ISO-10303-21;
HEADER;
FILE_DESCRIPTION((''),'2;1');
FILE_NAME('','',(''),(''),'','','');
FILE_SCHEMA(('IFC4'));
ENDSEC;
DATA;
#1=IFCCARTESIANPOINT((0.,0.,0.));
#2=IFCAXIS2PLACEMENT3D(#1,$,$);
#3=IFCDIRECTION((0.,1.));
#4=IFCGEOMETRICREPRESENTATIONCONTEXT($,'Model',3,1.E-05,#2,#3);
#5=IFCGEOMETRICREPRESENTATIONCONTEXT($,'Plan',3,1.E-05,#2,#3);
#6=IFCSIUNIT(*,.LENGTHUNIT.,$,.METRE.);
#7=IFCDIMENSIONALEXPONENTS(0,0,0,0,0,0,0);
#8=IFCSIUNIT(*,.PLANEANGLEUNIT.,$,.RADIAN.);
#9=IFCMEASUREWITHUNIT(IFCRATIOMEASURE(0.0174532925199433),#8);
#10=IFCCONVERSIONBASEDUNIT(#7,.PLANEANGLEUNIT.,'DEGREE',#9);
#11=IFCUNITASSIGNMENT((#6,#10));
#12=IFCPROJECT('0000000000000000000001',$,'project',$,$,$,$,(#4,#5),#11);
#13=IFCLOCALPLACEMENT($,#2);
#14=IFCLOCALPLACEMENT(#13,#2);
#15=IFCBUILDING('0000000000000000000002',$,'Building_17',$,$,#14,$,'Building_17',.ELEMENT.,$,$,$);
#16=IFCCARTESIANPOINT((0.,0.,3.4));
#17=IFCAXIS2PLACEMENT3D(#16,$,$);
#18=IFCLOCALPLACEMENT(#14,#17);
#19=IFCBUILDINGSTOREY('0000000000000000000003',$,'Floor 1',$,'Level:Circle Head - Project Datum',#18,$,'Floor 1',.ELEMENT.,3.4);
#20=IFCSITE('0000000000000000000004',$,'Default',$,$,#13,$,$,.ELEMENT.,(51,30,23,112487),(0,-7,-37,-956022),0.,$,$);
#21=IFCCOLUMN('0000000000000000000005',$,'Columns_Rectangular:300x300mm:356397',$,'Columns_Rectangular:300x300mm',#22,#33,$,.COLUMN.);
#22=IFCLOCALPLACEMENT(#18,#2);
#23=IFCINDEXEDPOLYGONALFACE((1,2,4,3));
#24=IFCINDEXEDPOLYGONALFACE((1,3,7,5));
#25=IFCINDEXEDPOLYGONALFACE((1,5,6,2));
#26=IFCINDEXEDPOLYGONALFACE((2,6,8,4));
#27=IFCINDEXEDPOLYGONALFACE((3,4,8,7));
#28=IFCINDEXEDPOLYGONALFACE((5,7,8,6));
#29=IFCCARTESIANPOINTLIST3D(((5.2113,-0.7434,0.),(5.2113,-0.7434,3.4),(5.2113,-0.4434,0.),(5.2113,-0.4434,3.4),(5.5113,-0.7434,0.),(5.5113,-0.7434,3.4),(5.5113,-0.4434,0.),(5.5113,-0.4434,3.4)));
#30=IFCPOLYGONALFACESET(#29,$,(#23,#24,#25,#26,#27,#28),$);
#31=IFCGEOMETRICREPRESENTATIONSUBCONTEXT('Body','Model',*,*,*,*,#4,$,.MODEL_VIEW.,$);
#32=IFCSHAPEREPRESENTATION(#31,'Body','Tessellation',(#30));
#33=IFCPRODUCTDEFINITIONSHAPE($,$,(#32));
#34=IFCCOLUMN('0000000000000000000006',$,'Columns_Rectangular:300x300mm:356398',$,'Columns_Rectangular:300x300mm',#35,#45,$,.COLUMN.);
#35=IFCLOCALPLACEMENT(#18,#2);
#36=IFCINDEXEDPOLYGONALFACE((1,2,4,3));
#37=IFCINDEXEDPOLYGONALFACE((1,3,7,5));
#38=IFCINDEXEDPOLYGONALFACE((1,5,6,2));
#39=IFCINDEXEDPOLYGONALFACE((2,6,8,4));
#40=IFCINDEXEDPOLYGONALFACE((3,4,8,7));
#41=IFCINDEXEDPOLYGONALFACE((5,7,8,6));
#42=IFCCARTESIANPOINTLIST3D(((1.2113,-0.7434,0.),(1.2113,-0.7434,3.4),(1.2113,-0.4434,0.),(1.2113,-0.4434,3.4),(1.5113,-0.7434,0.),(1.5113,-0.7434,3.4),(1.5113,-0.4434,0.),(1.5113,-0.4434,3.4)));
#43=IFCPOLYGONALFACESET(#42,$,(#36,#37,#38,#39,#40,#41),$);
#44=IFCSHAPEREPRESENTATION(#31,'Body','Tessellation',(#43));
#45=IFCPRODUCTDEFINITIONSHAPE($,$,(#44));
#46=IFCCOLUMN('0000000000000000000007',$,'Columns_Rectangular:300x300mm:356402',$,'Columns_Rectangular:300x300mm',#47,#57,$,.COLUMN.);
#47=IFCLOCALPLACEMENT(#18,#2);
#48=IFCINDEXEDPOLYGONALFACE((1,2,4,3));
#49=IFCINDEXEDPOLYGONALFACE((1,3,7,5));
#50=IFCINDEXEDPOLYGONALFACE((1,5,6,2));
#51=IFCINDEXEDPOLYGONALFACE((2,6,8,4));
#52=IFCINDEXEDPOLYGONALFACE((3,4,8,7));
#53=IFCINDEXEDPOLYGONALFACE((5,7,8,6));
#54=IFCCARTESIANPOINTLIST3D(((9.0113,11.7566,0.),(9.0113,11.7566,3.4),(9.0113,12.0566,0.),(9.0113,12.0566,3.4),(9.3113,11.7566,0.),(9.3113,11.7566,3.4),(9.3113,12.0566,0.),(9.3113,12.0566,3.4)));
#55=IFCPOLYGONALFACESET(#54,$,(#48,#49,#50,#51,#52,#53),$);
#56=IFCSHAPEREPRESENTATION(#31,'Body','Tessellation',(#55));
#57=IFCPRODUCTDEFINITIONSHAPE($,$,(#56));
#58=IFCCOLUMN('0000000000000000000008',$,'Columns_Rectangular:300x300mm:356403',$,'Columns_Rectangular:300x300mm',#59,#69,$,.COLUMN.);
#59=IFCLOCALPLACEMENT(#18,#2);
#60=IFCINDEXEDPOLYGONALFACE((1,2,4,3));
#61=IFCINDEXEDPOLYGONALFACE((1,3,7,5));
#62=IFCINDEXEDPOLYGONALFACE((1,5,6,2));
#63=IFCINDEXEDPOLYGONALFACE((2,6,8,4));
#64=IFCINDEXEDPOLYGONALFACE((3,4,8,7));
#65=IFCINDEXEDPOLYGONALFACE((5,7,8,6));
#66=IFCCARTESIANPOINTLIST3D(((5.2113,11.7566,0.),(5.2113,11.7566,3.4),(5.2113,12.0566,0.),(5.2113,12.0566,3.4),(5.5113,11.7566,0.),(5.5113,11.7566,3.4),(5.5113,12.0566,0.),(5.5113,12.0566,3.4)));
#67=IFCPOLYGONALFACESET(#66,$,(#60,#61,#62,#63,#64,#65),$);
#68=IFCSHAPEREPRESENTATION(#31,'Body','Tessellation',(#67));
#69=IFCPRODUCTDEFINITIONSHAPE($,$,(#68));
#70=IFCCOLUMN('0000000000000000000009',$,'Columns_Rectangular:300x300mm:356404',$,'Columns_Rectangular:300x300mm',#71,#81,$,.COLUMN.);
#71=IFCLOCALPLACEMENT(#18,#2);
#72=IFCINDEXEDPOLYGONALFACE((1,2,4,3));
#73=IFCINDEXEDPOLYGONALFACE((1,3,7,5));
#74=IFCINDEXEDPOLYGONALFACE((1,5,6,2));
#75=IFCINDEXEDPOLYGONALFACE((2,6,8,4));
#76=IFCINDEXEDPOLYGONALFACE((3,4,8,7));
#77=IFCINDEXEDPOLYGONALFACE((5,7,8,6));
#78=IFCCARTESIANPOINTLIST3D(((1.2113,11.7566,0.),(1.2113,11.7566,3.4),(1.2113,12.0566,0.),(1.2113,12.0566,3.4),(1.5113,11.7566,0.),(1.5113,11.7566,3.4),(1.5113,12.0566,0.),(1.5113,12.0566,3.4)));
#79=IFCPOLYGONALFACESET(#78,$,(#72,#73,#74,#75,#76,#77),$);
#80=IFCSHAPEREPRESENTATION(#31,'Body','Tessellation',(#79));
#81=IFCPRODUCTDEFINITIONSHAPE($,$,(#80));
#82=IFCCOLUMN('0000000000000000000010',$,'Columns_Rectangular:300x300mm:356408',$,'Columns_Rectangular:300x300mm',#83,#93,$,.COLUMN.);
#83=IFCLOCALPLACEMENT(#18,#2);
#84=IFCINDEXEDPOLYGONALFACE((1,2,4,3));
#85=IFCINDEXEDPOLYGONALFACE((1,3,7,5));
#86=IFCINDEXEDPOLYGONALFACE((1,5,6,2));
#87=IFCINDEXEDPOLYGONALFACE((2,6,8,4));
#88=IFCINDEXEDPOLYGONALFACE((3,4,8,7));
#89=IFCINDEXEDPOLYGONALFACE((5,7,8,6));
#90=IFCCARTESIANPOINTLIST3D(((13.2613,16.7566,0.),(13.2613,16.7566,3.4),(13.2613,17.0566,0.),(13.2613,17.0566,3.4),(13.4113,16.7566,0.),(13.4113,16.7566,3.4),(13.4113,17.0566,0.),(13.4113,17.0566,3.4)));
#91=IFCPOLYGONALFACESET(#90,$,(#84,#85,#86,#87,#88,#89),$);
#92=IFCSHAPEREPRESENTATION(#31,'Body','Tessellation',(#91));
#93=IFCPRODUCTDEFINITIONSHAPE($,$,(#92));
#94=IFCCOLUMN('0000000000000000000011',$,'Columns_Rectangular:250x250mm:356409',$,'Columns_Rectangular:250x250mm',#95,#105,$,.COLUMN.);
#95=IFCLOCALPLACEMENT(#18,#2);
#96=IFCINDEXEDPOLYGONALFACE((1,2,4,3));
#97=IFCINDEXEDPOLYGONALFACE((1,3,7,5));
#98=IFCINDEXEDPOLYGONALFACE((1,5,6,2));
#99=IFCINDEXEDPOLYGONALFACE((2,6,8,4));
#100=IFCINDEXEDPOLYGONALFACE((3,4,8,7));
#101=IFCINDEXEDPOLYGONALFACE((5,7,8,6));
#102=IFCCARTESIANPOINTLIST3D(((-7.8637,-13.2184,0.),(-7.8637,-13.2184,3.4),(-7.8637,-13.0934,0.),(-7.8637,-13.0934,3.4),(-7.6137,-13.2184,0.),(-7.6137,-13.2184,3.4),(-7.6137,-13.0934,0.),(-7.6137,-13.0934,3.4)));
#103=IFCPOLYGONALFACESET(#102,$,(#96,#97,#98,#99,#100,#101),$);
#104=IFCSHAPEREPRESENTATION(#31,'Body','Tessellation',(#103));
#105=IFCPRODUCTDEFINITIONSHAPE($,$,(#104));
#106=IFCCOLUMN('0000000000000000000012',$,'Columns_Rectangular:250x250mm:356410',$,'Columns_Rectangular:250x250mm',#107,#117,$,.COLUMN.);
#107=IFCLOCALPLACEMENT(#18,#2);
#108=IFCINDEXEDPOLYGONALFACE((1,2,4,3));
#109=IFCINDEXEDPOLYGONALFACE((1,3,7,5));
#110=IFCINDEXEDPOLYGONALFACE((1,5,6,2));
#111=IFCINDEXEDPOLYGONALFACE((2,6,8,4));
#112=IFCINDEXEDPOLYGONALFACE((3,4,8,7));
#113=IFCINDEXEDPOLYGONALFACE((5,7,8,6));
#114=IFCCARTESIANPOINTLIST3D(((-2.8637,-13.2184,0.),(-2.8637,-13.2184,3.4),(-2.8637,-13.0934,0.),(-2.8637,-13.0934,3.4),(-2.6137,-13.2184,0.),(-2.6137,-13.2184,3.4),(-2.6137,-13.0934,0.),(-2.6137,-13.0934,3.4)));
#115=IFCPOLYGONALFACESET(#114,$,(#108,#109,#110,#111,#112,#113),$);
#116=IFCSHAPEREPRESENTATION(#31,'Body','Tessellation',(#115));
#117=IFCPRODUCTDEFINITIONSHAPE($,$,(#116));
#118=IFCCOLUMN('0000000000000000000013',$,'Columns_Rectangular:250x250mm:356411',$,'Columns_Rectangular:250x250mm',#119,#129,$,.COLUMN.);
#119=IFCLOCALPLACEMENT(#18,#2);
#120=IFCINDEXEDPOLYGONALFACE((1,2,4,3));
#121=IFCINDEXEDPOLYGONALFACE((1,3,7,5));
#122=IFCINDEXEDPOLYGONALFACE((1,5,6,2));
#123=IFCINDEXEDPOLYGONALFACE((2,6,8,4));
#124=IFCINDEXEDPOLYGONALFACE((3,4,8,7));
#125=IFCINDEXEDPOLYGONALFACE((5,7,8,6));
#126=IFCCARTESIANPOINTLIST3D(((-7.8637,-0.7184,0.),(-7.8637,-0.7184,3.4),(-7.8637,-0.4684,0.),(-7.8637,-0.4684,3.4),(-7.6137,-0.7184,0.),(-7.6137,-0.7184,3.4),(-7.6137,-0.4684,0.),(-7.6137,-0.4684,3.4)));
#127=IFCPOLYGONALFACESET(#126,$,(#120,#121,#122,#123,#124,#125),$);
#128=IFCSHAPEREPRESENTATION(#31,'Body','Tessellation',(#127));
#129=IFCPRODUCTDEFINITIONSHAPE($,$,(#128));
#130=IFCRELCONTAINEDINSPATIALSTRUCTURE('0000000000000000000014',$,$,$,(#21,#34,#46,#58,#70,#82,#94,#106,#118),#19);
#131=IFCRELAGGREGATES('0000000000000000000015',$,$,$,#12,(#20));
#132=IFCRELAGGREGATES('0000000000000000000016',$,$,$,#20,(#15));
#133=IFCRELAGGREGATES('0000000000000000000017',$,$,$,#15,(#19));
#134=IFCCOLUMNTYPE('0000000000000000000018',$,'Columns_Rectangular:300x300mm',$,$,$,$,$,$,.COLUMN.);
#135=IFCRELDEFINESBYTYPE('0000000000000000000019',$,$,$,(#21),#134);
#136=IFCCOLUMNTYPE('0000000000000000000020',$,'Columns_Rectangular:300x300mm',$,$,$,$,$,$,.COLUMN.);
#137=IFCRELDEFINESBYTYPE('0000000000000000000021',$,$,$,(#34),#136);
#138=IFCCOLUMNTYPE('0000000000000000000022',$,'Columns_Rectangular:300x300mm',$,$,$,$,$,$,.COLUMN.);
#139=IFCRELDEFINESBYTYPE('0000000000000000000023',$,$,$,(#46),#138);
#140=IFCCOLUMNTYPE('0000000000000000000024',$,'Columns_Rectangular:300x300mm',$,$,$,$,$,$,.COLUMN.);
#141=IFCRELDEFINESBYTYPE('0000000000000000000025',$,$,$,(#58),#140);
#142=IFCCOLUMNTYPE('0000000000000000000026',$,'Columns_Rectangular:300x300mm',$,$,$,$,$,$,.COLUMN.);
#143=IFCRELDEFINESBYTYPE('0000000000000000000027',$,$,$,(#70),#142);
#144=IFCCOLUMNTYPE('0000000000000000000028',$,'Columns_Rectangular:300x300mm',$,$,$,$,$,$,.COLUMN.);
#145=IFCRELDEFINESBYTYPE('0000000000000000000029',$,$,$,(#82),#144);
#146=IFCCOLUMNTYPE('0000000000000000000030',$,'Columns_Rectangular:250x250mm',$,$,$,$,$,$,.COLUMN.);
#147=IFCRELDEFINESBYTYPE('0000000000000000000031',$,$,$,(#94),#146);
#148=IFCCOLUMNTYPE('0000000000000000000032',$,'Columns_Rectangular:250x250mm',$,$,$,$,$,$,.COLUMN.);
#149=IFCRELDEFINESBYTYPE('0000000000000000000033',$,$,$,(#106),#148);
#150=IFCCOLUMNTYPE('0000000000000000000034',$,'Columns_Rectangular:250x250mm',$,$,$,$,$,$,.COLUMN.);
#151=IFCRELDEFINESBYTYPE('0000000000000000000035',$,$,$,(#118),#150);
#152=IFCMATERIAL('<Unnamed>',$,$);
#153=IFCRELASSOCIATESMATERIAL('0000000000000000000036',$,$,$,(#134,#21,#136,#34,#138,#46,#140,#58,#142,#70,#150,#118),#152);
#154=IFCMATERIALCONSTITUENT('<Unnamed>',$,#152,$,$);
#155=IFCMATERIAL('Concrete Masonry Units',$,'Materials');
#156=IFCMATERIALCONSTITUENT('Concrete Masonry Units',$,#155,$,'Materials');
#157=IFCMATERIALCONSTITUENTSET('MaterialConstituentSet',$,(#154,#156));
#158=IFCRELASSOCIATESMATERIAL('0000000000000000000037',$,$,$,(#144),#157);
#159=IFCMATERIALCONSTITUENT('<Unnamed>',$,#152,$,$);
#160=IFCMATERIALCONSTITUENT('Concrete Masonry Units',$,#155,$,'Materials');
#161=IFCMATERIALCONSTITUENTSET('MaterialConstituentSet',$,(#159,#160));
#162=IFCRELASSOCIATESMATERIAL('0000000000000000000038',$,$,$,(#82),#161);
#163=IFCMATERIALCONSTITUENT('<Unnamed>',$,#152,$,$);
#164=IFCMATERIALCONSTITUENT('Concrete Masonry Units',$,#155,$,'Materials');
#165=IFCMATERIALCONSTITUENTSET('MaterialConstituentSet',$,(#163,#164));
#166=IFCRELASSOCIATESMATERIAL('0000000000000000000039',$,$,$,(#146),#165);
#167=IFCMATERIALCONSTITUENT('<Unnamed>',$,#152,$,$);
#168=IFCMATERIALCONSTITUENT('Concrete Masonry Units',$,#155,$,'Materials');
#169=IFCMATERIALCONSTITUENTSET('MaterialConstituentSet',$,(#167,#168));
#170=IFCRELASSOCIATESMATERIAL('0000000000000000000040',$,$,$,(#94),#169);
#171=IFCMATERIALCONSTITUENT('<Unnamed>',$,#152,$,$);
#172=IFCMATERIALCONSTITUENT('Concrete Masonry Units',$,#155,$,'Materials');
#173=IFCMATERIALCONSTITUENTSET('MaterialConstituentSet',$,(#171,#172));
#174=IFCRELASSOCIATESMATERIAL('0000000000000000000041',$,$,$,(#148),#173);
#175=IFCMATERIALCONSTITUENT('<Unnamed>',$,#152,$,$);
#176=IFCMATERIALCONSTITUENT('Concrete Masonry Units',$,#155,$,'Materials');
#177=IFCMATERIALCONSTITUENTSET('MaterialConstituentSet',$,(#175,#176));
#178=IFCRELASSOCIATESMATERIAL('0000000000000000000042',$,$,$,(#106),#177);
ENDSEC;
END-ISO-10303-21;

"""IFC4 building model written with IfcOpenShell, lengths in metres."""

from ifc_helpers import new_model, entity, si_unit, converted_unit, direction, frame, origin, place, context, subcontext, project, spatial, indexed_curve, outline, extrude, source, transform, mapped, material, constituent, constituent_set, type_object, type_shapes, element, save


model = new_model("IFC4")

# Units and contexts
model_context = context("Model", 3, precision=1e-05, world=origin(), true_north=direction((0.0, 1.0)))
plan_context = context("Plan", 3, precision=1e-05, world=origin(), true_north=direction((0.0, 1.0)))
body_context = subcontext(model_context, "Body", "Model", "MODEL_VIEW")
ifc_project = project(units=[si_unit("LENGTHUNIT", "METRE"), converted_unit("PLANEANGLEUNIT", "DEGREE", entity("IfcRatioMeasure", 0.0174532925199433), si_unit("PLANEANGLEUNIT", "RADIAN"), dimensions=[0, 0, 0, 0, 0, 0, 0])], contexts=[model_context, plan_context])

# Site, building, storey
site_placement = place(None, origin())
site = spatial("IfcSite", under=ifc_project, at=site_placement, Name="Default", CompositionType="ELEMENT", RefLatitude=(51, 30, 23, 112487), RefLongitude=(0, -7, -37, -956022), RefElevation=0.0)
building_placement = place(site_placement, origin())
building = spatial("IfcBuilding", under=site, at=building_placement, Name="Building_17", LongName="Building_17", CompositionType="ELEMENT")
storey_placement = place(building_placement, frame((0.0, 0.0, 3.4)))
storey = spatial("IfcBuildingStorey", under=building, at=storey_placement, Name="Floor 1", ObjectType="Level:Circle Head - Project Datum", LongName="Floor 1", CompositionType="ELEMENT", Elevation=3.4)

# Columns
ifc_material_1 = material(Name="<Unnamed>")
ifc_material_2 = material(Name="Concrete Masonry Units", Category="Materials")
column_type_1 = type_object("IfcColumnType", Name="Columns_Rectangular:300x300mm", PredefinedType="COLUMN", material=ifc_material_1)
shared_shape_1 = source(origin(), body_context, "Body", "SweptSolid", [
    extrude(outline(indexed_curve([(-0.15, -0.15), (0.15, -0.15), (0.15, 0.15), (-0.15, 0.15), (-0.15, -0.15)], self_intersect=False)), frame((5.3613, -0.5934, 3.4), z_axis=(0.0, 0.0, 1.0), x_axis=(0.0, -1.0, 0.0)), (0.0, 0.0, 1.0), 3.4),
])
type_shapes(column_type_1, [shared_shape_1])
column_1_placement = place(storey_placement, frame((0.0, 0.0, -3.4)))
element("IfcColumn", 1, at=column_1_placement, inside=storey, type_object=column_type_1, material=ifc_material_1, Name="Columns_Rectangular:300x300mm:356397", ObjectType="Columns_Rectangular:300x300mm", PredefinedType="COLUMN", context=body_context, shape_type="MappedRepresentation", body=[
    mapped(shared_shape_1, transform((0.0, 0.0, 0.0), scale=1.0)),
])
column_type_2 = type_object("IfcColumnType", Name="Columns_Rectangular:300x300mm", PredefinedType="COLUMN", material=ifc_material_1)
shared_shape_2 = source(origin(), body_context, "Body", "SweptSolid", [
    extrude(outline(indexed_curve([(-0.15, -0.15), (0.15, -0.15), (0.15, 0.15), (-0.15, 0.15), (-0.15, -0.15)], self_intersect=False)), frame((1.3613, -0.5934, 3.4), z_axis=(0.0, 0.0, 1.0), x_axis=(0.0, -1.0, 0.0)), (0.0, 0.0, 1.0), 3.4),
])
type_shapes(column_type_2, [shared_shape_2])
column_2_placement = place(storey_placement, frame((0.0, 0.0, -3.4)))
element("IfcColumn", 2, at=column_2_placement, inside=storey, type_object=column_type_2, material=ifc_material_1, Name="Columns_Rectangular:300x300mm:356398", ObjectType="Columns_Rectangular:300x300mm", PredefinedType="COLUMN", context=body_context, shape_type="MappedRepresentation", body=[
    mapped(shared_shape_2, transform((0.0, 0.0, 0.0), scale=1.0)),
])
column_type_3 = type_object("IfcColumnType", Name="Columns_Rectangular:300x300mm", PredefinedType="COLUMN", material=ifc_material_1)
shared_shape_3 = source(origin(), body_context, "Body", "SweptSolid", [
    extrude(outline(indexed_curve([(-0.15, -0.15), (0.15, -0.15), (0.15, 0.15), (-0.15, 0.15), (-0.15, -0.15)], self_intersect=False)), frame((9.1613, 11.9066, 3.4), z_axis=(0.0, 0.0, 1.0), x_axis=(0.0, -1.0, 0.0)), (0.0, 0.0, 1.0), 3.4),
])
type_shapes(column_type_3, [shared_shape_3])
column_3_placement = place(storey_placement, frame((0.0, 0.0, -3.4)))
element("IfcColumn", 3, at=column_3_placement, inside=storey, type_object=column_type_3, material=ifc_material_1, Name="Columns_Rectangular:300x300mm:356402", ObjectType="Columns_Rectangular:300x300mm", PredefinedType="COLUMN", context=body_context, shape_type="MappedRepresentation", body=[
    mapped(shared_shape_3, transform((0.0, 0.0, 0.0), scale=1.0)),
])
column_type_4 = type_object("IfcColumnType", Name="Columns_Rectangular:300x300mm", PredefinedType="COLUMN", material=ifc_material_1)
shared_shape_4 = source(origin(), body_context, "Body", "SweptSolid", [
    extrude(outline(indexed_curve([(-0.15, -0.15), (0.15, -0.15), (0.15, 0.15), (-0.15, 0.15), (-0.15, -0.15)], self_intersect=False)), frame((5.3613, 11.9066, 3.4), z_axis=(0.0, 0.0, 1.0), x_axis=(0.0, -1.0, 0.0)), (0.0, 0.0, 1.0), 3.4),
])
type_shapes(column_type_4, [shared_shape_4])
column_4_placement = place(storey_placement, frame((0.0, 0.0, -3.4)))
element("IfcColumn", 4, at=column_4_placement, inside=storey, type_object=column_type_4, material=ifc_material_1, Name="Columns_Rectangular:300x300mm:356403", ObjectType="Columns_Rectangular:300x300mm", PredefinedType="COLUMN", context=body_context, shape_type="MappedRepresentation", body=[
    mapped(shared_shape_4, transform((0.0, 0.0, 0.0), scale=1.0)),
])
column_type_5 = type_object("IfcColumnType", Name="Columns_Rectangular:300x300mm", PredefinedType="COLUMN", material=ifc_material_1)
shared_shape_5 = source(origin(), body_context, "Body", "SweptSolid", [
    extrude(outline(indexed_curve([(-0.15, -0.15), (0.15, -0.15), (0.15, 0.15), (-0.15, 0.15), (-0.15, -0.15)], self_intersect=False)), frame((1.3613, 11.9066, 3.4), z_axis=(0.0, 0.0, 1.0), x_axis=(0.0, -1.0, 0.0)), (0.0, 0.0, 1.0), 3.4),
])
type_shapes(column_type_5, [shared_shape_5])
column_5_placement = place(storey_placement, frame((0.0, 0.0, -3.4)))
element("IfcColumn", 5, at=column_5_placement, inside=storey, type_object=column_type_5, material=ifc_material_1, Name="Columns_Rectangular:300x300mm:356404", ObjectType="Columns_Rectangular:300x300mm", PredefinedType="COLUMN", context=body_context, shape_type="MappedRepresentation", body=[
    mapped(shared_shape_5, transform((0.0, 0.0, 0.0), scale=1.0)),
])
ifc_constituent_1 = constituent(ifc_material_1, Name="<Unnamed>")
ifc_constituent_2 = constituent(ifc_material_2, Name="Concrete Masonry Units", Category="Materials")
ifc_constituent_set_1 = constituent_set(constituents=[ifc_constituent_1, ifc_constituent_2], Name="MaterialConstituentSet")
ifc_constituent_3 = constituent(ifc_material_1, Name="<Unnamed>")
ifc_constituent_4 = constituent(ifc_material_2, Name="Concrete Masonry Units", Category="Materials")
ifc_constituent_set_2 = constituent_set(constituents=[ifc_constituent_3, ifc_constituent_4], Name="MaterialConstituentSet")
column_type_6 = type_object("IfcColumnType", Name="Columns_Rectangular:300x300mm", PredefinedType="COLUMN", material=ifc_constituent_set_2)
shared_shape_6 = source(origin(), body_context, "Body", "SweptSolid", [
    extrude(outline(indexed_curve([(-0.15, -0.075), (0.15, -0.075), (0.15, 0.075), (-0.15, 0.075), (-0.15, -0.075)], self_intersect=False)), frame((13.3363, 16.9066, 3.4), z_axis=(0.0, 0.0, 1.0), x_axis=(0.0, -1.0, 0.0)), (0.0, 0.0, 1.0), 3.4),
])
type_shapes(column_type_6, [shared_shape_6])
column_6_placement = place(storey_placement, frame((0.0, 0.0, -3.4)))
element("IfcColumn", 6, at=column_6_placement, inside=storey, type_object=column_type_6, material=ifc_constituent_set_1, Name="Columns_Rectangular:300x300mm:356408", ObjectType="Columns_Rectangular:300x300mm", PredefinedType="COLUMN", context=body_context, shape_type="MappedRepresentation", body=[
    mapped(shared_shape_6, transform((0.0, 0.0, 0.0), scale=1.0)),
])
ifc_constituent_5 = constituent(ifc_material_1, Name="<Unnamed>")
ifc_constituent_6 = constituent(ifc_material_2, Name="Concrete Masonry Units", Category="Materials")
ifc_constituent_set_3 = constituent_set(constituents=[ifc_constituent_5, ifc_constituent_6], Name="MaterialConstituentSet")
ifc_constituent_7 = constituent(ifc_material_1, Name="<Unnamed>")
ifc_constituent_8 = constituent(ifc_material_2, Name="Concrete Masonry Units", Category="Materials")
ifc_constituent_set_4 = constituent_set(constituents=[ifc_constituent_7, ifc_constituent_8], Name="MaterialConstituentSet")
column_type_7 = type_object("IfcColumnType", Name="Columns_Rectangular:250x250mm", PredefinedType="COLUMN", material=ifc_constituent_set_4)
shared_shape_7 = source(origin(), body_context, "Body", "SweptSolid", [
    extrude(outline(indexed_curve([(-0.0625, -0.125), (0.0625, -0.125), (0.0625, 0.125), (-0.0625, 0.125), (-0.0625, -0.125)], self_intersect=False)), frame((-7.7387, -13.1559, 3.4), z_axis=(0.0, 0.0, 1.0), x_axis=(0.0, -1.0, 0.0)), (0.0, 0.0, 1.0), 3.4),
])
type_shapes(column_type_7, [shared_shape_7])
column_7_placement = place(storey_placement, frame((0.0, 0.0, -3.4)))
element("IfcColumn", 7, at=column_7_placement, inside=storey, type_object=column_type_7, material=ifc_constituent_set_3, Name="Columns_Rectangular:250x250mm:356409", ObjectType="Columns_Rectangular:250x250mm", PredefinedType="COLUMN", context=body_context, shape_type="MappedRepresentation", body=[
    mapped(shared_shape_7, transform((0.0, 0.0, 0.0), scale=1.0)),
])
ifc_constituent_9 = constituent(ifc_material_1, Name="<Unnamed>")
ifc_constituent_10 = constituent(ifc_material_2, Name="Concrete Masonry Units", Category="Materials")
ifc_constituent_set_5 = constituent_set(constituents=[ifc_constituent_9, ifc_constituent_10], Name="MaterialConstituentSet")
ifc_constituent_11 = constituent(ifc_material_1, Name="<Unnamed>")
ifc_constituent_12 = constituent(ifc_material_2, Name="Concrete Masonry Units", Category="Materials")
ifc_constituent_set_6 = constituent_set(constituents=[ifc_constituent_11, ifc_constituent_12], Name="MaterialConstituentSet")
column_type_8 = type_object("IfcColumnType", Name="Columns_Rectangular:250x250mm", PredefinedType="COLUMN", material=ifc_constituent_set_6)
shared_shape_8 = source(origin(), body_context, "Body", "SweptSolid", [
    extrude(outline(indexed_curve([(-0.0625, -0.125), (0.0625, -0.125), (0.0625, 0.125), (-0.0625, 0.125), (-0.0625, -0.125)], self_intersect=False)), frame((-2.7387, -13.1559, 3.4), z_axis=(0.0, 0.0, 1.0), x_axis=(0.0, -1.0, 0.0)), (0.0, 0.0, 1.0), 3.4),
])
type_shapes(column_type_8, [shared_shape_8])
column_8_placement = place(storey_placement, frame((0.0, 0.0, -3.4)))
element("IfcColumn", 8, at=column_8_placement, inside=storey, type_object=column_type_8, material=ifc_constituent_set_5, Name="Columns_Rectangular:250x250mm:356410", ObjectType="Columns_Rectangular:250x250mm", PredefinedType="COLUMN", context=body_context, shape_type="MappedRepresentation", body=[
    mapped(shared_shape_8, transform((0.0, 0.0, 0.0), scale=1.0)),
])
column_type_9 = type_object("IfcColumnType", Name="Columns_Rectangular:250x250mm", PredefinedType="COLUMN", material=ifc_material_1)
shared_shape_9 = source(origin(), body_context, "Body", "SweptSolid", [
    extrude(outline(indexed_curve([(-0.125, -0.125), (0.125, -0.125), (0.125, 0.125), (-0.125, 0.125), (-0.125, -0.125)], self_intersect=False)), frame((-7.7387, -0.5934, 3.4), z_axis=(0.0, 0.0, 1.0), x_axis=(0.0, -1.0, 0.0)), (0.0, 0.0, 1.0), 3.4),
])
type_shapes(column_type_9, [shared_shape_9])
column_9_placement = place(storey_placement, frame((0.0, 0.0, -3.4)))
element("IfcColumn", 9, at=column_9_placement, inside=storey, type_object=column_type_9, material=ifc_material_1, Name="Columns_Rectangular:250x250mm:356411", ObjectType="Columns_Rectangular:250x250mm", PredefinedType="COLUMN", context=body_context, shape_type="MappedRepresentation", body=[
    mapped(shared_shape_9, transform((0.0, 0.0, 0.0), scale=1.0)),
])

save(model, "model.ifc")
